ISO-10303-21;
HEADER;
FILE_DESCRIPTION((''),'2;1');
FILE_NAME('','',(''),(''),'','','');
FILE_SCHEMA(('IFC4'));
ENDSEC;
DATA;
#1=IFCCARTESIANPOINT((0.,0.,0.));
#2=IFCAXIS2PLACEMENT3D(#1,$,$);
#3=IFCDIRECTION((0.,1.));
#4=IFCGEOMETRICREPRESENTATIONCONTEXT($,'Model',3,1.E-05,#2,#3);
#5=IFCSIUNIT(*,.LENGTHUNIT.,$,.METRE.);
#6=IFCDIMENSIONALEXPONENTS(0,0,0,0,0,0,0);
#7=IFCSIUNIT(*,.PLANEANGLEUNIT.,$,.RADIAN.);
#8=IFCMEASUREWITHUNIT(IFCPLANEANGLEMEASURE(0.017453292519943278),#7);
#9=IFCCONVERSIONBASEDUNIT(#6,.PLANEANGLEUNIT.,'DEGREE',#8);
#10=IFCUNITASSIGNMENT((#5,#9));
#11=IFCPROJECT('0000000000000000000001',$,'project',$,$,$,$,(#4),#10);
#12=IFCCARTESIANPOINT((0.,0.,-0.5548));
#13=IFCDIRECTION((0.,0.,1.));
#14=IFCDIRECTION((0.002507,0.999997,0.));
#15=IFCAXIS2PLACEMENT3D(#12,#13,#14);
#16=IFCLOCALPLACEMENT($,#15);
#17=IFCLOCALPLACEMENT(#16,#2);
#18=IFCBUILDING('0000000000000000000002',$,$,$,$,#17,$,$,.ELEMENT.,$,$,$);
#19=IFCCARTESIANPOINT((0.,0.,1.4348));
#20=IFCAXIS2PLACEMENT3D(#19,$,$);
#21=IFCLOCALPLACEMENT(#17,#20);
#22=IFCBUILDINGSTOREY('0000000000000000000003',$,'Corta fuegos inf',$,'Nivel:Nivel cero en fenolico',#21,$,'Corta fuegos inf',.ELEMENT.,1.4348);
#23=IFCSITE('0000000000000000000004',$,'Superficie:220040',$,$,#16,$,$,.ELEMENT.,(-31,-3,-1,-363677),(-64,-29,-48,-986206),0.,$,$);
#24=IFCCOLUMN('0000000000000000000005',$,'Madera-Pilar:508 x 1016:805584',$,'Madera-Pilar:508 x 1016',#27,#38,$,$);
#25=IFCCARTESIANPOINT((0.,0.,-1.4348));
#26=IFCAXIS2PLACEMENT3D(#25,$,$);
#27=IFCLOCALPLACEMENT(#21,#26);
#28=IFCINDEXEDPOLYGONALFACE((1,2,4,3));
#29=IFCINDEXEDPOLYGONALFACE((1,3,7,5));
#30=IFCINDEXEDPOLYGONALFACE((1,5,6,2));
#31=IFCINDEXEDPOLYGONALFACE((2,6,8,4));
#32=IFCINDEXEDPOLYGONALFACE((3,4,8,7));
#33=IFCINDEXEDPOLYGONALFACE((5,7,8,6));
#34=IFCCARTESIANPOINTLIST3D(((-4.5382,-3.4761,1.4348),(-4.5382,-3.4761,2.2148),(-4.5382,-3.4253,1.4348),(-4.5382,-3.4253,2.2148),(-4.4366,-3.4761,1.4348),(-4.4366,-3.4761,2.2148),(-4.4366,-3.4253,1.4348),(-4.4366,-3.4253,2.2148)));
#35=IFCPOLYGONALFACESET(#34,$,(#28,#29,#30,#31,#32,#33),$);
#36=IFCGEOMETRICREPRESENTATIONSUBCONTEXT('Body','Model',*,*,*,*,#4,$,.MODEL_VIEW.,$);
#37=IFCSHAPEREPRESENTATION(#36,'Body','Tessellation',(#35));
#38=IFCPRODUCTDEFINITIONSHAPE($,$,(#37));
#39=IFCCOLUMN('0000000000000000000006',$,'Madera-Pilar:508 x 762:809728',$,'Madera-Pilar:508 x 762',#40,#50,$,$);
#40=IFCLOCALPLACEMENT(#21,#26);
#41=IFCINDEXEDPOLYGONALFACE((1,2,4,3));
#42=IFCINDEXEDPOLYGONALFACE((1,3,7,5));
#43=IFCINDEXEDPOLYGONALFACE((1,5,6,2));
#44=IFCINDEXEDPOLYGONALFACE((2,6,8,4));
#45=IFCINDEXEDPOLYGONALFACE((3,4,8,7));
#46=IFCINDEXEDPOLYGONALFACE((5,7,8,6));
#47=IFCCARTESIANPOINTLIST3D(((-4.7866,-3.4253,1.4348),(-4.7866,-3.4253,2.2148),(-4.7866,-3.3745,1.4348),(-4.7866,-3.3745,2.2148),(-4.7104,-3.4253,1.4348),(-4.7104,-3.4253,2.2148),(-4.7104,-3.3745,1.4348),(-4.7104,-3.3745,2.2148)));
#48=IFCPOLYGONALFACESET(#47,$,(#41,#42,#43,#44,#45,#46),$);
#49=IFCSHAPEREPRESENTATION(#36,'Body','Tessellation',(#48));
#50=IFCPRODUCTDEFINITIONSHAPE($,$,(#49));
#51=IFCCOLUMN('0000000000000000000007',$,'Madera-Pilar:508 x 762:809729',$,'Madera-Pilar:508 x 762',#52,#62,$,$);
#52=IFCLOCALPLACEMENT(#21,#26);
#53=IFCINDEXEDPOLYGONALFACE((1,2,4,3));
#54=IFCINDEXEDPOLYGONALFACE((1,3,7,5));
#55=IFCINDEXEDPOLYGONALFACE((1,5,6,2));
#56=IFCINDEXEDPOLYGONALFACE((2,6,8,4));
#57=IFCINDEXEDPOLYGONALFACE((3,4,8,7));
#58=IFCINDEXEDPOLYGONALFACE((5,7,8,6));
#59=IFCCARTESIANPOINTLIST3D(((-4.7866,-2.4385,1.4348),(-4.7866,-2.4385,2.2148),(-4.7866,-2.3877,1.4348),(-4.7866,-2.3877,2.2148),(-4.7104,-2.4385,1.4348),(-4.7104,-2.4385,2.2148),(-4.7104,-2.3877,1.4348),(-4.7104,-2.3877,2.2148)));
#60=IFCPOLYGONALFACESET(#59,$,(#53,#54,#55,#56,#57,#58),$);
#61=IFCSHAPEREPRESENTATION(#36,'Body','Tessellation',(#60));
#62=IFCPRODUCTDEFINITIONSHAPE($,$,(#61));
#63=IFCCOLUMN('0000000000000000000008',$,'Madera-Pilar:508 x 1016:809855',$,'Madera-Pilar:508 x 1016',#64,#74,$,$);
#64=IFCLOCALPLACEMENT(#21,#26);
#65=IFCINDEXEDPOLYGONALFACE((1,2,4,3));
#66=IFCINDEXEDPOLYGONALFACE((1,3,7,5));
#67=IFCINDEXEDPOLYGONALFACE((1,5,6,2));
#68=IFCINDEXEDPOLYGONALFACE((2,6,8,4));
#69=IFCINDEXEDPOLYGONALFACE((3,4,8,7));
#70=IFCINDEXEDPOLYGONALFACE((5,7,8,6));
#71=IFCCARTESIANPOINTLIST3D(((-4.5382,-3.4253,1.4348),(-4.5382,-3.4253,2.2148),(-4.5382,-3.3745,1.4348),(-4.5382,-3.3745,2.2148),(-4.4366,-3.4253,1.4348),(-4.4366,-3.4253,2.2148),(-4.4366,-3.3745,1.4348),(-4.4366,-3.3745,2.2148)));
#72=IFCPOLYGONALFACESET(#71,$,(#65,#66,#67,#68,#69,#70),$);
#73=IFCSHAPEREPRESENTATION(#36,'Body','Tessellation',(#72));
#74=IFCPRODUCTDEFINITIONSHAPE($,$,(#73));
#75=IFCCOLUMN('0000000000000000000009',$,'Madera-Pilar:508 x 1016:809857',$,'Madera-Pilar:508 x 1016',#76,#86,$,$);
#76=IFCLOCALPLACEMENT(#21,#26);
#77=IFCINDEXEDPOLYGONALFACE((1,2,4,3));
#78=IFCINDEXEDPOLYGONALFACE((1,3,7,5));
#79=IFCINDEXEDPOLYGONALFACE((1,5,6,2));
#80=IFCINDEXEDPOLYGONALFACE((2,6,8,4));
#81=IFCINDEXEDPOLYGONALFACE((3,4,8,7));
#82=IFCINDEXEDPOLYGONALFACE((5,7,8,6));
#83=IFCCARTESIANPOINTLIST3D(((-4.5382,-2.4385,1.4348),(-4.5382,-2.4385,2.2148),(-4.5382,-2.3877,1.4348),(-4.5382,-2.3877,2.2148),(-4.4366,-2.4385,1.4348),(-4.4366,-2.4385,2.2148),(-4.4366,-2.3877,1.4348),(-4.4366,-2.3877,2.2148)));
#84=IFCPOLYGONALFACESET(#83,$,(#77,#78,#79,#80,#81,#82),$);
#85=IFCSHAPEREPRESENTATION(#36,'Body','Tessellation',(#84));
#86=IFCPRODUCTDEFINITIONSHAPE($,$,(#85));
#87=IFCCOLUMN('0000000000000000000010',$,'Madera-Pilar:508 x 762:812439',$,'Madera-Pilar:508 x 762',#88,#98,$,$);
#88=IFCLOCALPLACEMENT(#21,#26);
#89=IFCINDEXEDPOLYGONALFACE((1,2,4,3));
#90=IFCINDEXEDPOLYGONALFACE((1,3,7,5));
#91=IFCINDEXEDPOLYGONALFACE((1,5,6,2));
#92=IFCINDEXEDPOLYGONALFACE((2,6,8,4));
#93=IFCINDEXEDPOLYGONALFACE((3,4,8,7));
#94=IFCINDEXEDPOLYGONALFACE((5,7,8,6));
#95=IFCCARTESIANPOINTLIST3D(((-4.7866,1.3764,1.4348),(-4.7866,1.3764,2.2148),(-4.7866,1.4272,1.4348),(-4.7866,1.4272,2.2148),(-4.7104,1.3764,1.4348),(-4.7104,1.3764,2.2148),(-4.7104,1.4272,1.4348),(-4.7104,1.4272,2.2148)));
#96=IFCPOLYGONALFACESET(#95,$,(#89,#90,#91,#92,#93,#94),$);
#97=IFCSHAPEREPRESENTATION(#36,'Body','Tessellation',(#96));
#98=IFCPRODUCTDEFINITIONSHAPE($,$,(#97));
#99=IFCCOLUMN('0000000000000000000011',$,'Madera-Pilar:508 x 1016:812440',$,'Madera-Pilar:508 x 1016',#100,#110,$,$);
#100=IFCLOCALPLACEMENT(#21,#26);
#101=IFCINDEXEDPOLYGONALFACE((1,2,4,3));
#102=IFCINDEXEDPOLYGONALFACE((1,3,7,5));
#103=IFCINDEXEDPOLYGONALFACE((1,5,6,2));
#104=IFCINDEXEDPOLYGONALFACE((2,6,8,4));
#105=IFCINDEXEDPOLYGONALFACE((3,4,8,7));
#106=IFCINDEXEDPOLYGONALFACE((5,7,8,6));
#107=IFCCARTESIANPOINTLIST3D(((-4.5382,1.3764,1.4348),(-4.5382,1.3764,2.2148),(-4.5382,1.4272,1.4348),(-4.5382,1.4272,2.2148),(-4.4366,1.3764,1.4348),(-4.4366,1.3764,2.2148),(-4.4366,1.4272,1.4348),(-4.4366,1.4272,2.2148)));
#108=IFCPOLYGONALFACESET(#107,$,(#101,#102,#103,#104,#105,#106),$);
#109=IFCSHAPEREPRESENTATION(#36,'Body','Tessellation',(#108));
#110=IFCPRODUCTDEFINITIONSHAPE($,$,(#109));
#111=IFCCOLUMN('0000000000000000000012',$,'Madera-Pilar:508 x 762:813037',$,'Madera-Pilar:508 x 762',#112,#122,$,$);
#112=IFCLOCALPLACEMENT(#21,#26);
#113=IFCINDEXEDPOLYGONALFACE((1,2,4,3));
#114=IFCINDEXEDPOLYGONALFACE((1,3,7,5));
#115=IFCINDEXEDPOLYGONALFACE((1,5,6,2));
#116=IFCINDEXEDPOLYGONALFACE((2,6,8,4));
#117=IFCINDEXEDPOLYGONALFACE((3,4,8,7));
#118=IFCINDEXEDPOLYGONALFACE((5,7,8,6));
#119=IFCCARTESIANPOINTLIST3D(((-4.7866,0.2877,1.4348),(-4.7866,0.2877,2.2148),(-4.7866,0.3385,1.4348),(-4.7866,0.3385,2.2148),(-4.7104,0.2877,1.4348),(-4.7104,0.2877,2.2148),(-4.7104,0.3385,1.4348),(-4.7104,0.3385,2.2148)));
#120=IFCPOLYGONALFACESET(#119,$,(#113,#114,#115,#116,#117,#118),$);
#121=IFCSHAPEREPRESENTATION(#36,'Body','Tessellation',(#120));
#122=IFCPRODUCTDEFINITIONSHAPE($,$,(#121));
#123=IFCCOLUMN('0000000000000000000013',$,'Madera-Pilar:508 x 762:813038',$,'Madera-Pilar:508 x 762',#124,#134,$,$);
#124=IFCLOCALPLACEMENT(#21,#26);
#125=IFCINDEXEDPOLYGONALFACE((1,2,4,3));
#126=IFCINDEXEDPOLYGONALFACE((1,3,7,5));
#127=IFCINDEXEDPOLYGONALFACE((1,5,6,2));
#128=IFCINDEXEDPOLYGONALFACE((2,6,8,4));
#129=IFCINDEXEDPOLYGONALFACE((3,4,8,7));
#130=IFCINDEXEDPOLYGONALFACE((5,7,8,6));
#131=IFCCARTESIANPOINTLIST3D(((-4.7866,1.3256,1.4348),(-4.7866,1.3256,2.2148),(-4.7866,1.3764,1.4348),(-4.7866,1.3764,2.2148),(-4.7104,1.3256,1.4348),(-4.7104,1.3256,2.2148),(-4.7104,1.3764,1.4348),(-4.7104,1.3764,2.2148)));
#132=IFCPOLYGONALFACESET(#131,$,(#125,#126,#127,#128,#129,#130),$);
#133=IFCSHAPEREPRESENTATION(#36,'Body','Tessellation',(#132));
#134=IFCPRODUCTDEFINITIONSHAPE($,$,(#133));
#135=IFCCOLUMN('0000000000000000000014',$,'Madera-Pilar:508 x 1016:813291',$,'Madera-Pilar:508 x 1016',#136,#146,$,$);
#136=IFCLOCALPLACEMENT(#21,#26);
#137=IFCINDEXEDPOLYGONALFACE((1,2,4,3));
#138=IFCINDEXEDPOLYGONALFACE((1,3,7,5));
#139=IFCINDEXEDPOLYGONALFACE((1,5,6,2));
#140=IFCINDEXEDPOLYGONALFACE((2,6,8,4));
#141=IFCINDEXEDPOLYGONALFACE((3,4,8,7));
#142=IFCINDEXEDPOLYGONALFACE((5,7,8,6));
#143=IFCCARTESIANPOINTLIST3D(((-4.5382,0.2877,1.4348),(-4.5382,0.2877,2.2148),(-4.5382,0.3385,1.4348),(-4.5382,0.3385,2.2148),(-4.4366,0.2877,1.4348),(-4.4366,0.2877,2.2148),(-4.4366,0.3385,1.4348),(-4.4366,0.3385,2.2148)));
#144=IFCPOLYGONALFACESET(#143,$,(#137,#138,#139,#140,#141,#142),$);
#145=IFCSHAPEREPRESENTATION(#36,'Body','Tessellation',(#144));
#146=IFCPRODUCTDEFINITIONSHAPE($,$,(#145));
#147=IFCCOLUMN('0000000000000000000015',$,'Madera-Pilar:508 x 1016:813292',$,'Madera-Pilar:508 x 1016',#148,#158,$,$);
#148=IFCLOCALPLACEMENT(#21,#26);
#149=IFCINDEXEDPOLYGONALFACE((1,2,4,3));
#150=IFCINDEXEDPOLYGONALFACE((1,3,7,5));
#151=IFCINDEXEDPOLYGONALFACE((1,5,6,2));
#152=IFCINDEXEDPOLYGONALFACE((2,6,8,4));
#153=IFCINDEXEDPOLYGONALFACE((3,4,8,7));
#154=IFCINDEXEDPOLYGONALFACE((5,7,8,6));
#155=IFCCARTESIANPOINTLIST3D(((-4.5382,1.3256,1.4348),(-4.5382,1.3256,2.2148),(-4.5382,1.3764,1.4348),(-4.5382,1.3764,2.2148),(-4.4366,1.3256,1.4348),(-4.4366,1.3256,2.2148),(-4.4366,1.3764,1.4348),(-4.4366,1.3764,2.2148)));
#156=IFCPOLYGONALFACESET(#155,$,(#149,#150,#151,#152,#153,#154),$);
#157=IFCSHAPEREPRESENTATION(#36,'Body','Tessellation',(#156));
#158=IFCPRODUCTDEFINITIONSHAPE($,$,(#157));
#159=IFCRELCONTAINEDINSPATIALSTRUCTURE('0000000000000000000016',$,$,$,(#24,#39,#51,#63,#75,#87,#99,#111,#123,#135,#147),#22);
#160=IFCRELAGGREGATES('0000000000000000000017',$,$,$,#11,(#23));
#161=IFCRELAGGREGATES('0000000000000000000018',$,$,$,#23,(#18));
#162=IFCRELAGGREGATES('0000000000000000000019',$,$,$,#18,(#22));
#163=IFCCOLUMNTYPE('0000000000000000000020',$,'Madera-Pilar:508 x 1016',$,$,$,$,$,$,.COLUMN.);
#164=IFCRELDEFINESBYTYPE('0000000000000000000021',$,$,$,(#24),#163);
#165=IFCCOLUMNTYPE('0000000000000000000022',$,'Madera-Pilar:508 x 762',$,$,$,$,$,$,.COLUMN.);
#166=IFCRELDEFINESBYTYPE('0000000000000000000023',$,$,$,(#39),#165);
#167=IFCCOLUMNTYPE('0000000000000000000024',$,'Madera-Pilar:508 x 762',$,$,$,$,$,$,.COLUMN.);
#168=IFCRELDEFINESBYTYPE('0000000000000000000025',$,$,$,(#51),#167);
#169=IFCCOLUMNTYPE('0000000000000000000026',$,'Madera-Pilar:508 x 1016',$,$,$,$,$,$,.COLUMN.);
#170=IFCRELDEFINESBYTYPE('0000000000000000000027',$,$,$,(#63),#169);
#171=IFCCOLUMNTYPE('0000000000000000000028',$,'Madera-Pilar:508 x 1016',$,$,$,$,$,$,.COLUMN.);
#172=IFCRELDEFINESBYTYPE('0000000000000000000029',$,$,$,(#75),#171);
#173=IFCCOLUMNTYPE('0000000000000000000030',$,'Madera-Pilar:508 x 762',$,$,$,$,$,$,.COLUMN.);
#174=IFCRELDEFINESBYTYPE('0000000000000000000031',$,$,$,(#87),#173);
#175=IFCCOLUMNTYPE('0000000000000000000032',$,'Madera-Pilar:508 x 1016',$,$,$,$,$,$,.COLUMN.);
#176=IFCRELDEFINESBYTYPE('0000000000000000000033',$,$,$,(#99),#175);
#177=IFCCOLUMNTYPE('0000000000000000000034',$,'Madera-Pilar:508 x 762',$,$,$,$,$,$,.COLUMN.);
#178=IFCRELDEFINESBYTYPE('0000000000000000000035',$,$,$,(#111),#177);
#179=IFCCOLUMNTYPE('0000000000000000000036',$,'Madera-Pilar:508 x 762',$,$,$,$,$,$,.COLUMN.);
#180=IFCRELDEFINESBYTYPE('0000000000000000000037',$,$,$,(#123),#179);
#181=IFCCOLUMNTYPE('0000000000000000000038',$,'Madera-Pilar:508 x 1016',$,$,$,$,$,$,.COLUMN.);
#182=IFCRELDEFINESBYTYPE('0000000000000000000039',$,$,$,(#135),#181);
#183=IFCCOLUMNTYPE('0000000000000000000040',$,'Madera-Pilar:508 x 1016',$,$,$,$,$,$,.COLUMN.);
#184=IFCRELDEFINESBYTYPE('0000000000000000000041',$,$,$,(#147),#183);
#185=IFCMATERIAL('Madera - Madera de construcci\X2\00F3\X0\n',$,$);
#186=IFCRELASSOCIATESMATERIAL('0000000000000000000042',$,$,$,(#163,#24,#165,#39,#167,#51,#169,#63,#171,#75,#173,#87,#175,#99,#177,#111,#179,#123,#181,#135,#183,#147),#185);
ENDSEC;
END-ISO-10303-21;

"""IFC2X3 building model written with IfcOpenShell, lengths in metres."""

from ifc_helpers import new_model, entity, si_unit, converted_unit, direction, frame, frame_2d, origin, origin_2d_with_axis, place, context, subcontext, project, spatial, rectangle, extrude, source, transform, mapped, material, type_object, type_shapes, element, save


model = new_model("IFC2X3")

# Units and contexts
model_context = context("Model", 3, precision=1e-05, world=origin(), true_north=direction((0.0, 1.0)))
body_context = subcontext(model_context, "Body", "Model", "MODEL_VIEW")
ifc_project = project(units=[si_unit("LENGTHUNIT", "METRE"), converted_unit("PLANEANGLEUNIT", "DEGREE", entity("IfcPlaneAngleMeasure", 0.017453292519943278), si_unit("PLANEANGLEUNIT", "RADIAN"), dimensions=[0, 0, 0, 0, 0, 0, 0])], contexts=[model_context])

# Site, building, storey
site_placement = place(None, frame((0.0, 0.0, -0.5548), z_axis=(0.0, 0.0, 1.0), x_axis=(0.002507, 0.999997, 0.0)))
site = spatial("IfcSite", under=ifc_project, at=site_placement, Name="Superficie:220040", CompositionType="ELEMENT", RefLatitude=(-31, -3, -1, -363677), RefLongitude=(-64, -29, -48, -986206), RefElevation=0.0)
building_placement = place(site_placement, origin())
building = spatial("IfcBuilding", under=site, at=building_placement, CompositionType="ELEMENT")
storey_placement = place(building_placement, frame((0.0, 0.0, 1.4348)))
storey = spatial("IfcBuildingStorey", under=building, at=storey_placement, Name="Corta fuegos inf", ObjectType="Nivel:Nivel cero en fenolico", LongName="Corta fuegos inf", CompositionType="ELEMENT", Elevation=1.4348)

# Columns
ifc_material = material(Name="Madera - Madera de construcción")
column_type_1 = type_object("IfcColumnType", Name="Madera-Pilar:508 x 1016", PredefinedType="COLUMN", material=ifc_material)
shared_shape_1 = source(origin(), body_context, "Body", "SweptSolid", [
    extrude(rectangle(XDim=0.1016, YDim=0.0508, at=frame_2d((0.0, 0.0), x_axis=(1.0, 0.0))), frame((-4.4874, -3.4507, 1.4348), z_axis=(0.0, 0.0, 1.0), x_axis=(-1.0, 0.0, 0.0)), (0.0, 0.0, 1.0), 0.78),
])
type_shapes(column_type_1, [shared_shape_1])
column_1_placement = place(storey_placement, frame((0.0, 0.0, -1.4348)))
element("IfcColumn", 1, at=column_1_placement, inside=storey, type_object=column_type_1, material=ifc_material, Name="Madera-Pilar:508 x 1016:805584", ObjectType="Madera-Pilar:508 x 1016", context=body_context, shape_type="MappedRepresentation", body=[
    mapped(shared_shape_1, transform((0.0, 0.0, 0.0), scale=1.0)),
])
column_type_2 = type_object("IfcColumnType", Name="Madera-Pilar:508 x 762", PredefinedType="COLUMN", material=ifc_material)
shared_shape_2 = source(origin(), body_context, "Body", "SweptSolid", [
    extrude(rectangle(XDim=0.0762, YDim=0.0508, at=frame_2d((0.0, 0.0), x_axis=(1.0, 0.0))), frame((-4.7485, -3.3999, 1.4348), z_axis=(0.0, 0.0, 1.0), x_axis=(-1.0, 0.0, 0.0)), (0.0, 0.0, 1.0), 0.78),
])
type_shapes(column_type_2, [shared_shape_2])
column_2_placement = place(storey_placement, frame((0.0, 0.0, -1.4348)))
element("IfcColumn", 2, at=column_2_placement, inside=storey, type_object=column_type_2, material=ifc_material, Name="Madera-Pilar:508 x 762:809728", ObjectType="Madera-Pilar:508 x 762", context=body_context, shape_type="MappedRepresentation", body=[
    mapped(shared_shape_2, transform((0.0, 0.0, 0.0), scale=1.0)),
])
column_type_3 = type_object("IfcColumnType", Name="Madera-Pilar:508 x 762", PredefinedType="COLUMN", material=ifc_material)
shared_shape_3 = source(origin(), body_context, "Body", "SweptSolid", [
    extrude(rectangle(XDim=0.0762, YDim=0.0508, at=origin_2d_with_axis()), frame((-4.7485, -2.4131, 1.4348), z_axis=(0.0, 0.0, 1.0), x_axis=(-1.0, 0.0, 0.0)), (0.0, 0.0, 1.0), 0.78),
])
type_shapes(column_type_3, [shared_shape_3])
column_3_placement = place(storey_placement, frame((0.0, 0.0, -1.4348)))
element("IfcColumn", 3, at=column_3_placement, inside=storey, type_object=column_type_3, material=ifc_material, Name="Madera-Pilar:508 x 762:809729", ObjectType="Madera-Pilar:508 x 762", context=body_context, shape_type="MappedRepresentation", body=[
    mapped(shared_shape_3, transform((0.0, 0.0, 0.0), scale=1.0)),
])
column_type_4 = type_object("IfcColumnType", Name="Madera-Pilar:508 x 1016", PredefinedType="COLUMN", material=ifc_material)
shared_shape_4 = source(origin(), body_context, "Body", "SweptSolid", [
    extrude(rectangle(XDim=0.1016, YDim=0.0508, at=frame_2d((0.0, 0.0), x_axis=(1.0, 0.0))), frame((-4.4874, -3.3999, 1.4348), z_axis=(0.0, 0.0, 1.0), x_axis=(-1.0, 0.0, 0.0)), (0.0, 0.0, 1.0), 0.78),
])
type_shapes(column_type_4, [shared_shape_4])
column_4_placement = place(storey_placement, frame((0.0, 0.0, -1.4348)))
element("IfcColumn", 4, at=column_4_placement, inside=storey, type_object=column_type_4, material=ifc_material, Name="Madera-Pilar:508 x 1016:809855", ObjectType="Madera-Pilar:508 x 1016", context=body_context, shape_type="MappedRepresentation", body=[
    mapped(shared_shape_4, transform((0.0, 0.0, 0.0), scale=1.0)),
])
column_type_5 = type_object("IfcColumnType", Name="Madera-Pilar:508 x 1016", PredefinedType="COLUMN", material=ifc_material)
shared_shape_5 = source(origin(), body_context, "Body", "SweptSolid", [
    extrude(rectangle(XDim=0.1016, YDim=0.0508, at=frame_2d((0.0, 0.0), x_axis=(1.0, 0.0))), frame((-4.4874, -2.4131, 1.4348), z_axis=(0.0, 0.0, 1.0), x_axis=(-1.0, 0.0, 0.0)), (0.0, 0.0, 1.0), 0.78),
])
type_shapes(column_type_5, [shared_shape_5])
column_5_placement = place(storey_placement, frame((0.0, 0.0, -1.4348)))
element("IfcColumn", 5, at=column_5_placement, inside=storey, type_object=column_type_5, material=ifc_material, Name="Madera-Pilar:508 x 1016:809857", ObjectType="Madera-Pilar:508 x 1016", context=body_context, shape_type="MappedRepresentation", body=[
    mapped(shared_shape_5, transform((0.0, 0.0, 0.0), scale=1.0)),
])
column_type_6 = type_object("IfcColumnType", Name="Madera-Pilar:508 x 762", PredefinedType="COLUMN", material=ifc_material)
shared_shape_6 = source(origin(), body_context, "Body", "SweptSolid", [
    extrude(rectangle(XDim=0.0762, YDim=0.0508, at=origin_2d_with_axis()), frame((-4.7485, 1.4018, 1.4348), z_axis=(0.0, 0.0, 1.0), x_axis=(-1.0, 0.0, 0.0)), (0.0, 0.0, 1.0), 0.78),
])
type_shapes(column_type_6, [shared_shape_6])
column_6_placement = place(storey_placement, frame((0.0, 0.0, -1.4348)))
element("IfcColumn", 6, at=column_6_placement, inside=storey, type_object=column_type_6, material=ifc_material, Name="Madera-Pilar:508 x 762:812439", ObjectType="Madera-Pilar:508 x 762", context=body_context, shape_type="MappedRepresentation", body=[
    mapped(shared_shape_6, transform((0.0, 0.0, 0.0), scale=1.0)),
])
column_type_7 = type_object("IfcColumnType", Name="Madera-Pilar:508 x 1016", PredefinedType="COLUMN", material=ifc_material)
shared_shape_7 = source(origin(), body_context, "Body", "SweptSolid", [
    extrude(rectangle(XDim=0.1016, YDim=0.0508, at=frame_2d((0.0, 0.0), x_axis=(1.0, 0.0))), frame((-4.4874, 1.4018, 1.4348), z_axis=(0.0, 0.0, 1.0), x_axis=(-1.0, 0.0, 0.0)), (0.0, 0.0, 1.0), 0.78),
])
type_shapes(column_type_7, [shared_shape_7])
column_7_placement = place(storey_placement, frame((0.0, 0.0, -1.4348)))
element("IfcColumn", 7, at=column_7_placement, inside=storey, type_object=column_type_7, material=ifc_material, Name="Madera-Pilar:508 x 1016:812440", ObjectType="Madera-Pilar:508 x 1016", context=body_context, shape_type="MappedRepresentation", body=[
    mapped(shared_shape_7, transform((0.0, 0.0, 0.0), scale=1.0)),
])
column_type_8 = type_object("IfcColumnType", Name="Madera-Pilar:508 x 762", PredefinedType="COLUMN", material=ifc_material)
shared_shape_8 = source(origin(), body_context, "Body", "SweptSolid", [
    extrude(rectangle(XDim=0.0762, YDim=0.0508, at=frame_2d((0.0, 0.0), x_axis=(1.0, 0.0))), frame((-4.7485, 0.3131, 1.4348), z_axis=(0.0, 0.0, 1.0), x_axis=(-1.0, 0.0, 0.0)), (0.0, 0.0, 1.0), 0.78),
])
type_shapes(column_type_8, [shared_shape_8])
column_8_placement = place(storey_placement, frame((0.0, 0.0, -1.4348)))
element("IfcColumn", 8, at=column_8_placement, inside=storey, type_object=column_type_8, material=ifc_material, Name="Madera-Pilar:508 x 762:813037", ObjectType="Madera-Pilar:508 x 762", context=body_context, shape_type="MappedRepresentation", body=[
    mapped(shared_shape_8, transform((0.0, 0.0, 0.0), scale=1.0)),
])
column_type_9 = type_object("IfcColumnType", Name="Madera-Pilar:508 x 762", PredefinedType="COLUMN", material=ifc_material)
shared_shape_9 = source(origin(), body_context, "Body", "SweptSolid", [
    extrude(rectangle(XDim=0.0762, YDim=0.0508, at=frame_2d((0.0, 0.0), x_axis=(1.0, 0.0))), frame((-4.7485, 1.351, 1.4348), z_axis=(0.0, 0.0, 1.0), x_axis=(-1.0, 0.0, 0.0)), (0.0, 0.0, 1.0), 0.78),
])
type_shapes(column_type_9, [shared_shape_9])
column_9_placement = place(storey_placement, frame((0.0, 0.0, -1.4348)))
element("IfcColumn", 9, at=column_9_placement, inside=storey, type_object=column_type_9, material=ifc_material, Name="Madera-Pilar:508 x 762:813038", ObjectType="Madera-Pilar:508 x 762", context=body_context, shape_type="MappedRepresentation", body=[
    mapped(shared_shape_9, transform((0.0, 0.0, 0.0), scale=1.0)),
])
column_type_10 = type_object("IfcColumnType", Name="Madera-Pilar:508 x 1016", PredefinedType="COLUMN", material=ifc_material)
shared_shape_10 = source(origin(), body_context, "Body", "SweptSolid", [
    extrude(rectangle(XDim=0.1016, YDim=0.0508, at=frame_2d((0.0, 0.0), x_axis=(1.0, 0.0))), frame((-4.4874, 0.3131, 1.4348), z_axis=(0.0, 0.0, 1.0), x_axis=(-1.0, 0.0, 0.0)), (0.0, 0.0, 1.0), 0.78),
])
type_shapes(column_type_10, [shared_shape_10])
column_10_placement = place(storey_placement, frame((0.0, 0.0, -1.4348)))
element("IfcColumn", 10, at=column_10_placement, inside=storey, type_object=column_type_10, material=ifc_material, Name="Madera-Pilar:508 x 1016:813291", ObjectType="Madera-Pilar:508 x 1016", context=body_context, shape_type="MappedRepresentation", body=[
    mapped(shared_shape_10, transform((0.0, 0.0, 0.0), scale=1.0)),
])
column_type_11 = type_object("IfcColumnType", Name="Madera-Pilar:508 x 1016", PredefinedType="COLUMN", material=ifc_material)
shared_shape_11 = source(origin(), body_context, "Body", "SweptSolid", [
    extrude(rectangle(XDim=0.1016, YDim=0.0508, at=frame_2d((0.0, 0.0), x_axis=(1.0, 0.0))), frame((-4.4874, 1.351, 1.4348), z_axis=(0.0, 0.0, 1.0), x_axis=(-1.0, 0.0, 0.0)), (0.0, 0.0, 1.0), 0.78),
])
type_shapes(column_type_11, [shared_shape_11])
column_11_placement = place(storey_placement, frame((0.0, 0.0, -1.4348)))
element("IfcColumn", 11, at=column_11_placement, inside=storey, type_object=column_type_11, material=ifc_material, Name="Madera-Pilar:508 x 1016:813292", ObjectType="Madera-Pilar:508 x 1016", context=body_context, shape_type="MappedRepresentation", body=[
    mapped(shared_shape_11, transform((0.0, 0.0, 0.0), scale=1.0)),
])

save(model, "model.ifc")
